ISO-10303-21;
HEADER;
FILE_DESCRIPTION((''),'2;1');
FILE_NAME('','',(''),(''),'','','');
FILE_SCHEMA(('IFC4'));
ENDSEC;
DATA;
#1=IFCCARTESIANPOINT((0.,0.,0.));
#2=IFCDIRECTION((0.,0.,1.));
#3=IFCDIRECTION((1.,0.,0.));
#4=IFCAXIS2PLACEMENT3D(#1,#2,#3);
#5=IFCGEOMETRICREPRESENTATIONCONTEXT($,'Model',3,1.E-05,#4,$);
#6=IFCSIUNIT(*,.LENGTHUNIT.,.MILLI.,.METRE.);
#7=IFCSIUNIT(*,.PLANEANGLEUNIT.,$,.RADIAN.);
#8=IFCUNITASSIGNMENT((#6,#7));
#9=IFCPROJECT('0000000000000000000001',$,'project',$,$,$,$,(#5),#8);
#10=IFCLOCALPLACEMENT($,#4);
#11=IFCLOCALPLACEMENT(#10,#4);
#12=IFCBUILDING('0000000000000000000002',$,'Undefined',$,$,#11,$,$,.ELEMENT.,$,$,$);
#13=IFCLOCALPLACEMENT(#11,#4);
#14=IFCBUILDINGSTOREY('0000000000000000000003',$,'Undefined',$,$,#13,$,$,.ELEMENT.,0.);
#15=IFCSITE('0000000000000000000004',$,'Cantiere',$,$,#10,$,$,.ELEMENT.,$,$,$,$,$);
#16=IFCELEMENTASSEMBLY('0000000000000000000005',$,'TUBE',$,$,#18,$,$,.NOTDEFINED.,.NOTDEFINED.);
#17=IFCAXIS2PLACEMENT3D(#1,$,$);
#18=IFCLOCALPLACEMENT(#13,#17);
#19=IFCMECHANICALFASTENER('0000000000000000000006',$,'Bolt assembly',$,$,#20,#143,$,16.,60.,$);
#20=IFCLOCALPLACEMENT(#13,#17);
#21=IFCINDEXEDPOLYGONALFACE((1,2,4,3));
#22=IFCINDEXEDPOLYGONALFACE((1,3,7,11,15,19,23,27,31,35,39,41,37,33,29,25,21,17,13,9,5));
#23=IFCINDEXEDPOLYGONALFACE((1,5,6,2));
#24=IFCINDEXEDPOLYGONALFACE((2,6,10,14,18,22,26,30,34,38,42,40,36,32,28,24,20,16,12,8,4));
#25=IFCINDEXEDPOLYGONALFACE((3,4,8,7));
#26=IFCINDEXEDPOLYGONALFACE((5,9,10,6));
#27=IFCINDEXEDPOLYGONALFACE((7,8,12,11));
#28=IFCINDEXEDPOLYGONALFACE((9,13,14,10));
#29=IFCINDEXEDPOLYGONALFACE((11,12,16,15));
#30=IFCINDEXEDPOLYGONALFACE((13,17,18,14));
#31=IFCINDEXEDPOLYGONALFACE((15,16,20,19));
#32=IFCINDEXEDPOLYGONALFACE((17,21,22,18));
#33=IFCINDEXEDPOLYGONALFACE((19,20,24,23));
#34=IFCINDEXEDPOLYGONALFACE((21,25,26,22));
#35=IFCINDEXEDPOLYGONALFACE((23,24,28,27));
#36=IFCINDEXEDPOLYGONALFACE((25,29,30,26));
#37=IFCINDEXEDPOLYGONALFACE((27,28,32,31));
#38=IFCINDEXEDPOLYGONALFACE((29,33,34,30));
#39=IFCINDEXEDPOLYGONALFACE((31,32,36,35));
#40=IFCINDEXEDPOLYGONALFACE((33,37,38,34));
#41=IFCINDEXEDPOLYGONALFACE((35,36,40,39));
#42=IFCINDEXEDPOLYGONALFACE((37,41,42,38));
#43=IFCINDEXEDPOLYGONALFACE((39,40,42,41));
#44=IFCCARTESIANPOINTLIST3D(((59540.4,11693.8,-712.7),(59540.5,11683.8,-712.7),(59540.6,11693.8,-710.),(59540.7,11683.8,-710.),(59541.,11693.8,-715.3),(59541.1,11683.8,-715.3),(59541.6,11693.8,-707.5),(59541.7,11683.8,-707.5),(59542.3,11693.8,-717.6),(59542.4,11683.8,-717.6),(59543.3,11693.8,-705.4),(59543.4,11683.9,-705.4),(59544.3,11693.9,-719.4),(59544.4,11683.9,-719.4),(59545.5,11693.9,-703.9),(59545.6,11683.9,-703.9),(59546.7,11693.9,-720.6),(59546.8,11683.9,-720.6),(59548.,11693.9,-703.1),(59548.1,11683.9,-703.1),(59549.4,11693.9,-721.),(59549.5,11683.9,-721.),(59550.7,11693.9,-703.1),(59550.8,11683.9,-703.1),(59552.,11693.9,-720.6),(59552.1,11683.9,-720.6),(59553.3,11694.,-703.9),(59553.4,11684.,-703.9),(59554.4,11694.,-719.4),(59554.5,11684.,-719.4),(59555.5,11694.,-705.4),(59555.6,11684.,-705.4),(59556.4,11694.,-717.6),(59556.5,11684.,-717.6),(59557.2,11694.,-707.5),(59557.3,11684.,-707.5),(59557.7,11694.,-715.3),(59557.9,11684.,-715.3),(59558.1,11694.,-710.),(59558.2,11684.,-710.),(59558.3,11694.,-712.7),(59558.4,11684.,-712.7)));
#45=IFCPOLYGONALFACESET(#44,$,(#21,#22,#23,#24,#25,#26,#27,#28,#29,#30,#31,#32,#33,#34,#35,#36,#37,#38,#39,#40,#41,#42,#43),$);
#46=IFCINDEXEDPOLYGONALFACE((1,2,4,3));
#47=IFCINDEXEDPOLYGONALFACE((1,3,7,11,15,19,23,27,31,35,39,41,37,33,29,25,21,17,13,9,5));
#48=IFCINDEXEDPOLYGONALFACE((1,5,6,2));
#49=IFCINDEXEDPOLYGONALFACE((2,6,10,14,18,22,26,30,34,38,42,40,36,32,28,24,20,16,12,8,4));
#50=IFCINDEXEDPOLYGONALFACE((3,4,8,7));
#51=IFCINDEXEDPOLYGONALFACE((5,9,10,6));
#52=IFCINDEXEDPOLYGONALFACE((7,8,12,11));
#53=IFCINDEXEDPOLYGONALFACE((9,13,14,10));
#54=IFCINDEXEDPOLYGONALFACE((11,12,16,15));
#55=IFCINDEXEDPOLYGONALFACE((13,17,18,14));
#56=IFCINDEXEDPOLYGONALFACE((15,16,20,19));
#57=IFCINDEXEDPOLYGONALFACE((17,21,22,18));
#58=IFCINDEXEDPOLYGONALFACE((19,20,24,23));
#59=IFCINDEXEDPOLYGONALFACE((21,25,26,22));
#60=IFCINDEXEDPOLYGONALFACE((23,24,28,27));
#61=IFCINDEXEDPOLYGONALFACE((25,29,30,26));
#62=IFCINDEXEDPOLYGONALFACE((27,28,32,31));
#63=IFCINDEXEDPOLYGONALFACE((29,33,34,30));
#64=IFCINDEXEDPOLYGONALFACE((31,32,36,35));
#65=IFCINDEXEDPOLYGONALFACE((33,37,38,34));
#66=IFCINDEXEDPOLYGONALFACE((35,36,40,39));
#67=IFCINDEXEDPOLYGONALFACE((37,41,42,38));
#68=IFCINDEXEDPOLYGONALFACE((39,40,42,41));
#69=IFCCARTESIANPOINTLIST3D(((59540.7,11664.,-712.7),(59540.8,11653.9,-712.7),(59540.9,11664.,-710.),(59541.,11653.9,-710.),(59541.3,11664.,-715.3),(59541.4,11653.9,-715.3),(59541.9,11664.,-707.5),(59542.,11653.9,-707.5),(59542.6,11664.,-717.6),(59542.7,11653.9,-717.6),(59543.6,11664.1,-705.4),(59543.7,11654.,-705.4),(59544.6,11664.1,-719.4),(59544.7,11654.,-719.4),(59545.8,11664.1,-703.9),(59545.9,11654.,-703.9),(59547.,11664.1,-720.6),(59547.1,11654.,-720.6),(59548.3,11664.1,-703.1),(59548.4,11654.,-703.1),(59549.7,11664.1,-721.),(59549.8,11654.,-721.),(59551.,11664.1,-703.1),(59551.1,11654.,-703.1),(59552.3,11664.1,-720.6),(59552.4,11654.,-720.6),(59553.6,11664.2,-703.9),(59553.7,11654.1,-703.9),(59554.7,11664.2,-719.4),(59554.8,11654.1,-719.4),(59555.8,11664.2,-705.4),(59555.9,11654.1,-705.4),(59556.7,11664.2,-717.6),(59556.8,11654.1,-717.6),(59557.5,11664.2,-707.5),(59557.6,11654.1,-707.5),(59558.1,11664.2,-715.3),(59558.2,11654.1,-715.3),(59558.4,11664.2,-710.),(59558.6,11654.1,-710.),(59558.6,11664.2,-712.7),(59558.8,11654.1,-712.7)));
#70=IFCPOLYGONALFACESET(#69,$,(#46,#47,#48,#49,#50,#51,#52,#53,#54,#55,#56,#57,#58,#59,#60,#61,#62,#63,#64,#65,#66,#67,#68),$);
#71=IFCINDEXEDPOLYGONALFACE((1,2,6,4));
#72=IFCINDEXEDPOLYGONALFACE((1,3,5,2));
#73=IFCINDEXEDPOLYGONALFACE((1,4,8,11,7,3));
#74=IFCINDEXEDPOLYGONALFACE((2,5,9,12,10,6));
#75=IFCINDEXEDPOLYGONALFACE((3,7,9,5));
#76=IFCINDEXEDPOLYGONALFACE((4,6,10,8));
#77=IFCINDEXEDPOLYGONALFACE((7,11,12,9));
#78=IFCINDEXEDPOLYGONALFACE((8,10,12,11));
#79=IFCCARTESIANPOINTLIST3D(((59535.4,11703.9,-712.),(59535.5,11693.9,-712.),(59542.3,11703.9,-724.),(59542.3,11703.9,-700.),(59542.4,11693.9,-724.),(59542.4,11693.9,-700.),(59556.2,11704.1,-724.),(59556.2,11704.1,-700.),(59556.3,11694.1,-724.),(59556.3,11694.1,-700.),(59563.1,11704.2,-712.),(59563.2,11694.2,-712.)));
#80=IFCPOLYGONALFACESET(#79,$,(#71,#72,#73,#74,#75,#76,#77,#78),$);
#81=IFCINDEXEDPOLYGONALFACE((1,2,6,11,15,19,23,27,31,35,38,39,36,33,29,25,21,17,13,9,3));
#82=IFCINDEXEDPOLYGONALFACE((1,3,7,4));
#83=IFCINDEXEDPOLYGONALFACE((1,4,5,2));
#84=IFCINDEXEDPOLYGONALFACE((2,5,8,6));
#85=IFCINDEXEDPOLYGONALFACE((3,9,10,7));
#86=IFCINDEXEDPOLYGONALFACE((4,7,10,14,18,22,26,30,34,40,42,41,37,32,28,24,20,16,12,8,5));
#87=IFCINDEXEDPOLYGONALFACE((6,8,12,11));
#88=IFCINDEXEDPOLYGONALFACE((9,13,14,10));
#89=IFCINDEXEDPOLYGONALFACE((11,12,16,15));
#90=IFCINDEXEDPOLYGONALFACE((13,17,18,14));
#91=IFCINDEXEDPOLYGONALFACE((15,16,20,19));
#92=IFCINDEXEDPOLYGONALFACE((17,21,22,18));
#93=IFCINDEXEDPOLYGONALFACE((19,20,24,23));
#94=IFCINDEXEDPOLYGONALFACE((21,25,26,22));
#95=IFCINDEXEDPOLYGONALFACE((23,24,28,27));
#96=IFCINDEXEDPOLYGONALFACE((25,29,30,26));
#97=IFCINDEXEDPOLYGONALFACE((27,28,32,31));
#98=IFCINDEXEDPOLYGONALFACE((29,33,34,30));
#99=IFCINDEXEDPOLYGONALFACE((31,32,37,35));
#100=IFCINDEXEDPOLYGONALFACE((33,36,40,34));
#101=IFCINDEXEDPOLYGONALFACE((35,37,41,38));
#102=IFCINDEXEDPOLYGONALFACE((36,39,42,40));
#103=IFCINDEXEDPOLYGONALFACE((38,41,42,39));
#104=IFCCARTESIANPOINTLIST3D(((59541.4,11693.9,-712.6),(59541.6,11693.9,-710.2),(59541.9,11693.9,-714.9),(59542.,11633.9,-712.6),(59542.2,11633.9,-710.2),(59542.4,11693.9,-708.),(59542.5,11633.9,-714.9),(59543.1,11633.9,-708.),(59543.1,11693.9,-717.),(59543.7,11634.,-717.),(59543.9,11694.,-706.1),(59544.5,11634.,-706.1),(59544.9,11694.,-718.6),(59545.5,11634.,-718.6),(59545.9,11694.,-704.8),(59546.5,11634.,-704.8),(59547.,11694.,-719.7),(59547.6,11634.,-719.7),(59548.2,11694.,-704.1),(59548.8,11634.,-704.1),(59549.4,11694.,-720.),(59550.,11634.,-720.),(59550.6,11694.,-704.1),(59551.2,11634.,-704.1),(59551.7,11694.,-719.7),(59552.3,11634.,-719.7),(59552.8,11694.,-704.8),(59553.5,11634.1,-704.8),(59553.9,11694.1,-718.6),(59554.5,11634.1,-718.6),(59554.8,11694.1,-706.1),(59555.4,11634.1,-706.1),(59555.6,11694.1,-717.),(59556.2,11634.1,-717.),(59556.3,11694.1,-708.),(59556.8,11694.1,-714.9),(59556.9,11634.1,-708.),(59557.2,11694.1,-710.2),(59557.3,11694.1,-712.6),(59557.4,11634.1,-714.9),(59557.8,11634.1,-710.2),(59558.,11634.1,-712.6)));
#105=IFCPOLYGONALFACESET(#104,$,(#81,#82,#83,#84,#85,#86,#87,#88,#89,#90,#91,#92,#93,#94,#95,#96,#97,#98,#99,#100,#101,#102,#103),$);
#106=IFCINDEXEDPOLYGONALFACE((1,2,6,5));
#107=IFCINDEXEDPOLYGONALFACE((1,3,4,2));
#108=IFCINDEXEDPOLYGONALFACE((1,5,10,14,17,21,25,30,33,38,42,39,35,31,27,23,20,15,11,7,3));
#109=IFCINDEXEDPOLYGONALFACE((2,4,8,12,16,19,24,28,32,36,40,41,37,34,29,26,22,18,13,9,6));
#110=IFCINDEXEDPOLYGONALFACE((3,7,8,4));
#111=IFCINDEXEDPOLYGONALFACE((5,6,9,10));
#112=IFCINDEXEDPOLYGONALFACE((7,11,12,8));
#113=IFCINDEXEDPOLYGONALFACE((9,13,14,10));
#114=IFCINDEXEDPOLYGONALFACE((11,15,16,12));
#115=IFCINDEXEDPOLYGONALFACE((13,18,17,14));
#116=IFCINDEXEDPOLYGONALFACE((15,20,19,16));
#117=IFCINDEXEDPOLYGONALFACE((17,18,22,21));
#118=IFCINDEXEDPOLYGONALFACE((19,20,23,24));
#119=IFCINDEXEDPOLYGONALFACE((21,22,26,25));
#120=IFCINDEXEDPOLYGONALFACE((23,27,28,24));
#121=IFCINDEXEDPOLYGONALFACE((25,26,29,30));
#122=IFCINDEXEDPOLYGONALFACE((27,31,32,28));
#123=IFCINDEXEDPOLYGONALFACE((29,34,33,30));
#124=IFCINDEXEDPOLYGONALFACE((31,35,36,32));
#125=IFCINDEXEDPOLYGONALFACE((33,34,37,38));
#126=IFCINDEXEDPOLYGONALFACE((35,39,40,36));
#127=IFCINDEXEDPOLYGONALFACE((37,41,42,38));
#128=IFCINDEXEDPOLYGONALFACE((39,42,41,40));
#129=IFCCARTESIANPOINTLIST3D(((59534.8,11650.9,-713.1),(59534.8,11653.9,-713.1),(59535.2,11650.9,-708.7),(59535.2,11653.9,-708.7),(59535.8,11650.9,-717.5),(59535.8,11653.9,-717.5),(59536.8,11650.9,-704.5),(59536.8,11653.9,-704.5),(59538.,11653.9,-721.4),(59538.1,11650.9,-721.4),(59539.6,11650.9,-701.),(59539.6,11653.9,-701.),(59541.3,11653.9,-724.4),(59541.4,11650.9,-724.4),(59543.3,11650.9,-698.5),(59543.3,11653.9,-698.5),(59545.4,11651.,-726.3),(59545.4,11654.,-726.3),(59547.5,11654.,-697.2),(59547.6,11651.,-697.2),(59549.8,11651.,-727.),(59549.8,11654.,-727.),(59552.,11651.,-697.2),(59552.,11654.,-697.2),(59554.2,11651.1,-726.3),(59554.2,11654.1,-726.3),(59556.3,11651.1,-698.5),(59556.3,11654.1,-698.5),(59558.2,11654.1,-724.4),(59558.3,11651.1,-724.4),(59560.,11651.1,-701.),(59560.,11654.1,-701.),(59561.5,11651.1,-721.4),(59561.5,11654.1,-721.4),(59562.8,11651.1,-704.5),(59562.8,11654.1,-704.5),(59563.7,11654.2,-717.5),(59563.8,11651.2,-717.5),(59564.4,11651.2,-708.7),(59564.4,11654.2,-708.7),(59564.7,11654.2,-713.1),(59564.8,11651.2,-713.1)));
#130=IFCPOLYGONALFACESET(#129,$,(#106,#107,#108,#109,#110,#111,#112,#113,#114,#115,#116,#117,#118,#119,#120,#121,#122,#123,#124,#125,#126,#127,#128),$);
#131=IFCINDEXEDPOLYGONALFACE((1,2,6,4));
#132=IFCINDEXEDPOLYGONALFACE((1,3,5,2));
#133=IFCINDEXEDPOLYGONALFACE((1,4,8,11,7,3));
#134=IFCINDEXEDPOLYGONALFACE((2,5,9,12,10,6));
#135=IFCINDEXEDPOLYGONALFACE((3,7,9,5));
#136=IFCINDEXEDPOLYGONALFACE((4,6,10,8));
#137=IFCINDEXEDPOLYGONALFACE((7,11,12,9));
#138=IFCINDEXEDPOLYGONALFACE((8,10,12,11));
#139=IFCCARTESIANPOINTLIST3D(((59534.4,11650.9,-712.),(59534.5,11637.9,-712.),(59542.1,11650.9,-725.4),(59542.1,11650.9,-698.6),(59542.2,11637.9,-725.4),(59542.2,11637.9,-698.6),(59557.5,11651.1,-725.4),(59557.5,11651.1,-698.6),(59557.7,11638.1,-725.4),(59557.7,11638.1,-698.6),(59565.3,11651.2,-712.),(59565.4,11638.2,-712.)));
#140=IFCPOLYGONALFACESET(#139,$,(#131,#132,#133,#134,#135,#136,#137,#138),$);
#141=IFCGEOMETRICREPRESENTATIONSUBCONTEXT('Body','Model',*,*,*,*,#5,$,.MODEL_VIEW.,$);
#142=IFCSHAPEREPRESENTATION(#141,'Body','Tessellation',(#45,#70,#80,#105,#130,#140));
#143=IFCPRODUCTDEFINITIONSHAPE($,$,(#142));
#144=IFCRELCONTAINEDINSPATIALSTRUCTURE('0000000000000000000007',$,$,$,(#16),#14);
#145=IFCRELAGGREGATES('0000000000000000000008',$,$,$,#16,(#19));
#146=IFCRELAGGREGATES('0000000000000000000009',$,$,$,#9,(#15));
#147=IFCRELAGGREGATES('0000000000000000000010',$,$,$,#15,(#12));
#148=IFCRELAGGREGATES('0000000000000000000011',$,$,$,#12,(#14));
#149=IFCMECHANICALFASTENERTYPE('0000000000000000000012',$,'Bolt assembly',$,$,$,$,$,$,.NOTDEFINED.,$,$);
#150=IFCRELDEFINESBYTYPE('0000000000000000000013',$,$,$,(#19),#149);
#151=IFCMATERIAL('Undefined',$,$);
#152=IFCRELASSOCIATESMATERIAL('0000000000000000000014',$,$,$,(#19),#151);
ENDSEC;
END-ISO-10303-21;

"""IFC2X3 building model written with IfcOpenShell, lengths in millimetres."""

from ifc_helpers import new_model, si_unit, frame, origin_with_axes, origin_2d_with_axis, place, context, subcontext, project, spatial, polyline, circle, outline, extrude, source, transform, mapped, material, type_object, element, aggregate, save


model = new_model("IFC2X3")

# Units and contexts
model_context = context("Model", 3, precision=1e-05, world=origin_with_axes())
body_context = subcontext(model_context, "Body", "Model", "MODEL_VIEW")
ifc_project = project(units=[si_unit("LENGTHUNIT", "METRE", prefix="MILLI"), si_unit("PLANEANGLEUNIT", "RADIAN")], contexts=[model_context])

# Site, building, storey
site_placement = place(None, origin_with_axes())
site = spatial("IfcSite", under=ifc_project, at=site_placement, Name="Cantiere", CompositionType="ELEMENT")
building_placement = place(site_placement, origin_with_axes())
building = spatial("IfcBuilding", under=site, at=building_placement, Name="Undefined", CompositionType="ELEMENT")
storey_placement = place(building_placement, origin_with_axes())
storey = spatial("IfcBuildingStorey", under=building, at=storey_placement, Name="Undefined", CompositionType="ELEMENT", Elevation=0.0)

# Element assembly
assembly_1_placement = place(storey_placement, origin_with_axes())
assembly_1 = element("IfcElementAssembly", 1, at=assembly_1_placement, inside=storey, Name="TUBE", AssemblyPlace="NOTDEFINED", PredefinedType="NOTDEFINED")

# Mechanical fastener
ifc_material_1 = material(Name="Undefined")
mechanical_fastener_type = type_object("IfcMechanicalFastenerType", Name="Bolt assembly")
shared_shape_1 = source(origin_with_axes(), body_context, "Body", "SweptSolid", [
    extrude(circle(Radius=9.0, at=origin_2d_with_axis()), frame((0.0, -19.9, 0.0), z_axis=(0.0, 1.0, 0.0), x_axis=(1.0, 0.0, 0.0)), (0.0, 0.0, 1.0), 10.0),
    extrude(circle(Radius=9.0, at=origin_2d_with_axis()), frame((0.0, 9.9, 0.0), z_axis=(0.0, 1.0, 0.0), x_axis=(1.0, 0.0, 0.0)), (0.0, 0.0, 1.0), 10.1),
    extrude(outline(polyline([(12.0, -6.9), (12.0, 6.9), (0.0, 13.9), (-12.0, 6.9), (-12.0, -6.9), (0.0, -13.9), (12.0, -6.9)])), frame((0.0, -30.0, 0.0), z_axis=(0.0, 1.0, 0.0), x_axis=(1.0, 0.0, 0.0)), (0.0, 0.0, 1.0), 10.0),
    extrude(circle(Radius=8.0, at=origin_2d_with_axis()), frame((0.0, -20.0, 0.0), z_axis=(0.0, 1.0, 0.0), x_axis=(1.0, 0.0, 0.0)), (0.0, 0.0, 1.0), 60.0),
    extrude(circle(Radius=15.0, at=origin_2d_with_axis()), frame((0.0, 20.0, 0.0), z_axis=(0.0, 1.0, 0.0), x_axis=(1.0, 0.0, 0.0)), (0.0, 0.0, 1.0), 3.0),
    extrude(outline(polyline([(13.4, -7.7), (13.4, 7.7), (0.0, 15.4), (-13.4, 7.7), (-13.4, -7.7), (0.0, -15.4), (13.4, -7.7)])), frame((0.0, 23.0, 0.0), z_axis=(0.0, 1.0, 0.0), x_axis=(1.0, 0.0, 0.0)), (0.0, 0.0, 1.0), 13.0),
])
mechanical_fastener_1_placement = place(assembly_1_placement, frame((59549.6, 11674.0, -712.0), z_axis=(-0.999949, -0.010139, 0.0), x_axis=(0.0, 0.000001, -1.0)))
mechanical_fastener_1 = element("IfcMechanicalFastener", 2, at=mechanical_fastener_1_placement, type_object=mechanical_fastener_type, material=ifc_material_1, Name="Bolt assembly", NominalDiameter=16.0, NominalLength=60.0, context=body_context, shape_type="MappedRepresentation", body=[
    mapped(shared_shape_1, transform((0.0, 0.0, 0.0))),
])
aggregate(assembly_1, [mechanical_fastener_1])

save(model, "model.ifc")
